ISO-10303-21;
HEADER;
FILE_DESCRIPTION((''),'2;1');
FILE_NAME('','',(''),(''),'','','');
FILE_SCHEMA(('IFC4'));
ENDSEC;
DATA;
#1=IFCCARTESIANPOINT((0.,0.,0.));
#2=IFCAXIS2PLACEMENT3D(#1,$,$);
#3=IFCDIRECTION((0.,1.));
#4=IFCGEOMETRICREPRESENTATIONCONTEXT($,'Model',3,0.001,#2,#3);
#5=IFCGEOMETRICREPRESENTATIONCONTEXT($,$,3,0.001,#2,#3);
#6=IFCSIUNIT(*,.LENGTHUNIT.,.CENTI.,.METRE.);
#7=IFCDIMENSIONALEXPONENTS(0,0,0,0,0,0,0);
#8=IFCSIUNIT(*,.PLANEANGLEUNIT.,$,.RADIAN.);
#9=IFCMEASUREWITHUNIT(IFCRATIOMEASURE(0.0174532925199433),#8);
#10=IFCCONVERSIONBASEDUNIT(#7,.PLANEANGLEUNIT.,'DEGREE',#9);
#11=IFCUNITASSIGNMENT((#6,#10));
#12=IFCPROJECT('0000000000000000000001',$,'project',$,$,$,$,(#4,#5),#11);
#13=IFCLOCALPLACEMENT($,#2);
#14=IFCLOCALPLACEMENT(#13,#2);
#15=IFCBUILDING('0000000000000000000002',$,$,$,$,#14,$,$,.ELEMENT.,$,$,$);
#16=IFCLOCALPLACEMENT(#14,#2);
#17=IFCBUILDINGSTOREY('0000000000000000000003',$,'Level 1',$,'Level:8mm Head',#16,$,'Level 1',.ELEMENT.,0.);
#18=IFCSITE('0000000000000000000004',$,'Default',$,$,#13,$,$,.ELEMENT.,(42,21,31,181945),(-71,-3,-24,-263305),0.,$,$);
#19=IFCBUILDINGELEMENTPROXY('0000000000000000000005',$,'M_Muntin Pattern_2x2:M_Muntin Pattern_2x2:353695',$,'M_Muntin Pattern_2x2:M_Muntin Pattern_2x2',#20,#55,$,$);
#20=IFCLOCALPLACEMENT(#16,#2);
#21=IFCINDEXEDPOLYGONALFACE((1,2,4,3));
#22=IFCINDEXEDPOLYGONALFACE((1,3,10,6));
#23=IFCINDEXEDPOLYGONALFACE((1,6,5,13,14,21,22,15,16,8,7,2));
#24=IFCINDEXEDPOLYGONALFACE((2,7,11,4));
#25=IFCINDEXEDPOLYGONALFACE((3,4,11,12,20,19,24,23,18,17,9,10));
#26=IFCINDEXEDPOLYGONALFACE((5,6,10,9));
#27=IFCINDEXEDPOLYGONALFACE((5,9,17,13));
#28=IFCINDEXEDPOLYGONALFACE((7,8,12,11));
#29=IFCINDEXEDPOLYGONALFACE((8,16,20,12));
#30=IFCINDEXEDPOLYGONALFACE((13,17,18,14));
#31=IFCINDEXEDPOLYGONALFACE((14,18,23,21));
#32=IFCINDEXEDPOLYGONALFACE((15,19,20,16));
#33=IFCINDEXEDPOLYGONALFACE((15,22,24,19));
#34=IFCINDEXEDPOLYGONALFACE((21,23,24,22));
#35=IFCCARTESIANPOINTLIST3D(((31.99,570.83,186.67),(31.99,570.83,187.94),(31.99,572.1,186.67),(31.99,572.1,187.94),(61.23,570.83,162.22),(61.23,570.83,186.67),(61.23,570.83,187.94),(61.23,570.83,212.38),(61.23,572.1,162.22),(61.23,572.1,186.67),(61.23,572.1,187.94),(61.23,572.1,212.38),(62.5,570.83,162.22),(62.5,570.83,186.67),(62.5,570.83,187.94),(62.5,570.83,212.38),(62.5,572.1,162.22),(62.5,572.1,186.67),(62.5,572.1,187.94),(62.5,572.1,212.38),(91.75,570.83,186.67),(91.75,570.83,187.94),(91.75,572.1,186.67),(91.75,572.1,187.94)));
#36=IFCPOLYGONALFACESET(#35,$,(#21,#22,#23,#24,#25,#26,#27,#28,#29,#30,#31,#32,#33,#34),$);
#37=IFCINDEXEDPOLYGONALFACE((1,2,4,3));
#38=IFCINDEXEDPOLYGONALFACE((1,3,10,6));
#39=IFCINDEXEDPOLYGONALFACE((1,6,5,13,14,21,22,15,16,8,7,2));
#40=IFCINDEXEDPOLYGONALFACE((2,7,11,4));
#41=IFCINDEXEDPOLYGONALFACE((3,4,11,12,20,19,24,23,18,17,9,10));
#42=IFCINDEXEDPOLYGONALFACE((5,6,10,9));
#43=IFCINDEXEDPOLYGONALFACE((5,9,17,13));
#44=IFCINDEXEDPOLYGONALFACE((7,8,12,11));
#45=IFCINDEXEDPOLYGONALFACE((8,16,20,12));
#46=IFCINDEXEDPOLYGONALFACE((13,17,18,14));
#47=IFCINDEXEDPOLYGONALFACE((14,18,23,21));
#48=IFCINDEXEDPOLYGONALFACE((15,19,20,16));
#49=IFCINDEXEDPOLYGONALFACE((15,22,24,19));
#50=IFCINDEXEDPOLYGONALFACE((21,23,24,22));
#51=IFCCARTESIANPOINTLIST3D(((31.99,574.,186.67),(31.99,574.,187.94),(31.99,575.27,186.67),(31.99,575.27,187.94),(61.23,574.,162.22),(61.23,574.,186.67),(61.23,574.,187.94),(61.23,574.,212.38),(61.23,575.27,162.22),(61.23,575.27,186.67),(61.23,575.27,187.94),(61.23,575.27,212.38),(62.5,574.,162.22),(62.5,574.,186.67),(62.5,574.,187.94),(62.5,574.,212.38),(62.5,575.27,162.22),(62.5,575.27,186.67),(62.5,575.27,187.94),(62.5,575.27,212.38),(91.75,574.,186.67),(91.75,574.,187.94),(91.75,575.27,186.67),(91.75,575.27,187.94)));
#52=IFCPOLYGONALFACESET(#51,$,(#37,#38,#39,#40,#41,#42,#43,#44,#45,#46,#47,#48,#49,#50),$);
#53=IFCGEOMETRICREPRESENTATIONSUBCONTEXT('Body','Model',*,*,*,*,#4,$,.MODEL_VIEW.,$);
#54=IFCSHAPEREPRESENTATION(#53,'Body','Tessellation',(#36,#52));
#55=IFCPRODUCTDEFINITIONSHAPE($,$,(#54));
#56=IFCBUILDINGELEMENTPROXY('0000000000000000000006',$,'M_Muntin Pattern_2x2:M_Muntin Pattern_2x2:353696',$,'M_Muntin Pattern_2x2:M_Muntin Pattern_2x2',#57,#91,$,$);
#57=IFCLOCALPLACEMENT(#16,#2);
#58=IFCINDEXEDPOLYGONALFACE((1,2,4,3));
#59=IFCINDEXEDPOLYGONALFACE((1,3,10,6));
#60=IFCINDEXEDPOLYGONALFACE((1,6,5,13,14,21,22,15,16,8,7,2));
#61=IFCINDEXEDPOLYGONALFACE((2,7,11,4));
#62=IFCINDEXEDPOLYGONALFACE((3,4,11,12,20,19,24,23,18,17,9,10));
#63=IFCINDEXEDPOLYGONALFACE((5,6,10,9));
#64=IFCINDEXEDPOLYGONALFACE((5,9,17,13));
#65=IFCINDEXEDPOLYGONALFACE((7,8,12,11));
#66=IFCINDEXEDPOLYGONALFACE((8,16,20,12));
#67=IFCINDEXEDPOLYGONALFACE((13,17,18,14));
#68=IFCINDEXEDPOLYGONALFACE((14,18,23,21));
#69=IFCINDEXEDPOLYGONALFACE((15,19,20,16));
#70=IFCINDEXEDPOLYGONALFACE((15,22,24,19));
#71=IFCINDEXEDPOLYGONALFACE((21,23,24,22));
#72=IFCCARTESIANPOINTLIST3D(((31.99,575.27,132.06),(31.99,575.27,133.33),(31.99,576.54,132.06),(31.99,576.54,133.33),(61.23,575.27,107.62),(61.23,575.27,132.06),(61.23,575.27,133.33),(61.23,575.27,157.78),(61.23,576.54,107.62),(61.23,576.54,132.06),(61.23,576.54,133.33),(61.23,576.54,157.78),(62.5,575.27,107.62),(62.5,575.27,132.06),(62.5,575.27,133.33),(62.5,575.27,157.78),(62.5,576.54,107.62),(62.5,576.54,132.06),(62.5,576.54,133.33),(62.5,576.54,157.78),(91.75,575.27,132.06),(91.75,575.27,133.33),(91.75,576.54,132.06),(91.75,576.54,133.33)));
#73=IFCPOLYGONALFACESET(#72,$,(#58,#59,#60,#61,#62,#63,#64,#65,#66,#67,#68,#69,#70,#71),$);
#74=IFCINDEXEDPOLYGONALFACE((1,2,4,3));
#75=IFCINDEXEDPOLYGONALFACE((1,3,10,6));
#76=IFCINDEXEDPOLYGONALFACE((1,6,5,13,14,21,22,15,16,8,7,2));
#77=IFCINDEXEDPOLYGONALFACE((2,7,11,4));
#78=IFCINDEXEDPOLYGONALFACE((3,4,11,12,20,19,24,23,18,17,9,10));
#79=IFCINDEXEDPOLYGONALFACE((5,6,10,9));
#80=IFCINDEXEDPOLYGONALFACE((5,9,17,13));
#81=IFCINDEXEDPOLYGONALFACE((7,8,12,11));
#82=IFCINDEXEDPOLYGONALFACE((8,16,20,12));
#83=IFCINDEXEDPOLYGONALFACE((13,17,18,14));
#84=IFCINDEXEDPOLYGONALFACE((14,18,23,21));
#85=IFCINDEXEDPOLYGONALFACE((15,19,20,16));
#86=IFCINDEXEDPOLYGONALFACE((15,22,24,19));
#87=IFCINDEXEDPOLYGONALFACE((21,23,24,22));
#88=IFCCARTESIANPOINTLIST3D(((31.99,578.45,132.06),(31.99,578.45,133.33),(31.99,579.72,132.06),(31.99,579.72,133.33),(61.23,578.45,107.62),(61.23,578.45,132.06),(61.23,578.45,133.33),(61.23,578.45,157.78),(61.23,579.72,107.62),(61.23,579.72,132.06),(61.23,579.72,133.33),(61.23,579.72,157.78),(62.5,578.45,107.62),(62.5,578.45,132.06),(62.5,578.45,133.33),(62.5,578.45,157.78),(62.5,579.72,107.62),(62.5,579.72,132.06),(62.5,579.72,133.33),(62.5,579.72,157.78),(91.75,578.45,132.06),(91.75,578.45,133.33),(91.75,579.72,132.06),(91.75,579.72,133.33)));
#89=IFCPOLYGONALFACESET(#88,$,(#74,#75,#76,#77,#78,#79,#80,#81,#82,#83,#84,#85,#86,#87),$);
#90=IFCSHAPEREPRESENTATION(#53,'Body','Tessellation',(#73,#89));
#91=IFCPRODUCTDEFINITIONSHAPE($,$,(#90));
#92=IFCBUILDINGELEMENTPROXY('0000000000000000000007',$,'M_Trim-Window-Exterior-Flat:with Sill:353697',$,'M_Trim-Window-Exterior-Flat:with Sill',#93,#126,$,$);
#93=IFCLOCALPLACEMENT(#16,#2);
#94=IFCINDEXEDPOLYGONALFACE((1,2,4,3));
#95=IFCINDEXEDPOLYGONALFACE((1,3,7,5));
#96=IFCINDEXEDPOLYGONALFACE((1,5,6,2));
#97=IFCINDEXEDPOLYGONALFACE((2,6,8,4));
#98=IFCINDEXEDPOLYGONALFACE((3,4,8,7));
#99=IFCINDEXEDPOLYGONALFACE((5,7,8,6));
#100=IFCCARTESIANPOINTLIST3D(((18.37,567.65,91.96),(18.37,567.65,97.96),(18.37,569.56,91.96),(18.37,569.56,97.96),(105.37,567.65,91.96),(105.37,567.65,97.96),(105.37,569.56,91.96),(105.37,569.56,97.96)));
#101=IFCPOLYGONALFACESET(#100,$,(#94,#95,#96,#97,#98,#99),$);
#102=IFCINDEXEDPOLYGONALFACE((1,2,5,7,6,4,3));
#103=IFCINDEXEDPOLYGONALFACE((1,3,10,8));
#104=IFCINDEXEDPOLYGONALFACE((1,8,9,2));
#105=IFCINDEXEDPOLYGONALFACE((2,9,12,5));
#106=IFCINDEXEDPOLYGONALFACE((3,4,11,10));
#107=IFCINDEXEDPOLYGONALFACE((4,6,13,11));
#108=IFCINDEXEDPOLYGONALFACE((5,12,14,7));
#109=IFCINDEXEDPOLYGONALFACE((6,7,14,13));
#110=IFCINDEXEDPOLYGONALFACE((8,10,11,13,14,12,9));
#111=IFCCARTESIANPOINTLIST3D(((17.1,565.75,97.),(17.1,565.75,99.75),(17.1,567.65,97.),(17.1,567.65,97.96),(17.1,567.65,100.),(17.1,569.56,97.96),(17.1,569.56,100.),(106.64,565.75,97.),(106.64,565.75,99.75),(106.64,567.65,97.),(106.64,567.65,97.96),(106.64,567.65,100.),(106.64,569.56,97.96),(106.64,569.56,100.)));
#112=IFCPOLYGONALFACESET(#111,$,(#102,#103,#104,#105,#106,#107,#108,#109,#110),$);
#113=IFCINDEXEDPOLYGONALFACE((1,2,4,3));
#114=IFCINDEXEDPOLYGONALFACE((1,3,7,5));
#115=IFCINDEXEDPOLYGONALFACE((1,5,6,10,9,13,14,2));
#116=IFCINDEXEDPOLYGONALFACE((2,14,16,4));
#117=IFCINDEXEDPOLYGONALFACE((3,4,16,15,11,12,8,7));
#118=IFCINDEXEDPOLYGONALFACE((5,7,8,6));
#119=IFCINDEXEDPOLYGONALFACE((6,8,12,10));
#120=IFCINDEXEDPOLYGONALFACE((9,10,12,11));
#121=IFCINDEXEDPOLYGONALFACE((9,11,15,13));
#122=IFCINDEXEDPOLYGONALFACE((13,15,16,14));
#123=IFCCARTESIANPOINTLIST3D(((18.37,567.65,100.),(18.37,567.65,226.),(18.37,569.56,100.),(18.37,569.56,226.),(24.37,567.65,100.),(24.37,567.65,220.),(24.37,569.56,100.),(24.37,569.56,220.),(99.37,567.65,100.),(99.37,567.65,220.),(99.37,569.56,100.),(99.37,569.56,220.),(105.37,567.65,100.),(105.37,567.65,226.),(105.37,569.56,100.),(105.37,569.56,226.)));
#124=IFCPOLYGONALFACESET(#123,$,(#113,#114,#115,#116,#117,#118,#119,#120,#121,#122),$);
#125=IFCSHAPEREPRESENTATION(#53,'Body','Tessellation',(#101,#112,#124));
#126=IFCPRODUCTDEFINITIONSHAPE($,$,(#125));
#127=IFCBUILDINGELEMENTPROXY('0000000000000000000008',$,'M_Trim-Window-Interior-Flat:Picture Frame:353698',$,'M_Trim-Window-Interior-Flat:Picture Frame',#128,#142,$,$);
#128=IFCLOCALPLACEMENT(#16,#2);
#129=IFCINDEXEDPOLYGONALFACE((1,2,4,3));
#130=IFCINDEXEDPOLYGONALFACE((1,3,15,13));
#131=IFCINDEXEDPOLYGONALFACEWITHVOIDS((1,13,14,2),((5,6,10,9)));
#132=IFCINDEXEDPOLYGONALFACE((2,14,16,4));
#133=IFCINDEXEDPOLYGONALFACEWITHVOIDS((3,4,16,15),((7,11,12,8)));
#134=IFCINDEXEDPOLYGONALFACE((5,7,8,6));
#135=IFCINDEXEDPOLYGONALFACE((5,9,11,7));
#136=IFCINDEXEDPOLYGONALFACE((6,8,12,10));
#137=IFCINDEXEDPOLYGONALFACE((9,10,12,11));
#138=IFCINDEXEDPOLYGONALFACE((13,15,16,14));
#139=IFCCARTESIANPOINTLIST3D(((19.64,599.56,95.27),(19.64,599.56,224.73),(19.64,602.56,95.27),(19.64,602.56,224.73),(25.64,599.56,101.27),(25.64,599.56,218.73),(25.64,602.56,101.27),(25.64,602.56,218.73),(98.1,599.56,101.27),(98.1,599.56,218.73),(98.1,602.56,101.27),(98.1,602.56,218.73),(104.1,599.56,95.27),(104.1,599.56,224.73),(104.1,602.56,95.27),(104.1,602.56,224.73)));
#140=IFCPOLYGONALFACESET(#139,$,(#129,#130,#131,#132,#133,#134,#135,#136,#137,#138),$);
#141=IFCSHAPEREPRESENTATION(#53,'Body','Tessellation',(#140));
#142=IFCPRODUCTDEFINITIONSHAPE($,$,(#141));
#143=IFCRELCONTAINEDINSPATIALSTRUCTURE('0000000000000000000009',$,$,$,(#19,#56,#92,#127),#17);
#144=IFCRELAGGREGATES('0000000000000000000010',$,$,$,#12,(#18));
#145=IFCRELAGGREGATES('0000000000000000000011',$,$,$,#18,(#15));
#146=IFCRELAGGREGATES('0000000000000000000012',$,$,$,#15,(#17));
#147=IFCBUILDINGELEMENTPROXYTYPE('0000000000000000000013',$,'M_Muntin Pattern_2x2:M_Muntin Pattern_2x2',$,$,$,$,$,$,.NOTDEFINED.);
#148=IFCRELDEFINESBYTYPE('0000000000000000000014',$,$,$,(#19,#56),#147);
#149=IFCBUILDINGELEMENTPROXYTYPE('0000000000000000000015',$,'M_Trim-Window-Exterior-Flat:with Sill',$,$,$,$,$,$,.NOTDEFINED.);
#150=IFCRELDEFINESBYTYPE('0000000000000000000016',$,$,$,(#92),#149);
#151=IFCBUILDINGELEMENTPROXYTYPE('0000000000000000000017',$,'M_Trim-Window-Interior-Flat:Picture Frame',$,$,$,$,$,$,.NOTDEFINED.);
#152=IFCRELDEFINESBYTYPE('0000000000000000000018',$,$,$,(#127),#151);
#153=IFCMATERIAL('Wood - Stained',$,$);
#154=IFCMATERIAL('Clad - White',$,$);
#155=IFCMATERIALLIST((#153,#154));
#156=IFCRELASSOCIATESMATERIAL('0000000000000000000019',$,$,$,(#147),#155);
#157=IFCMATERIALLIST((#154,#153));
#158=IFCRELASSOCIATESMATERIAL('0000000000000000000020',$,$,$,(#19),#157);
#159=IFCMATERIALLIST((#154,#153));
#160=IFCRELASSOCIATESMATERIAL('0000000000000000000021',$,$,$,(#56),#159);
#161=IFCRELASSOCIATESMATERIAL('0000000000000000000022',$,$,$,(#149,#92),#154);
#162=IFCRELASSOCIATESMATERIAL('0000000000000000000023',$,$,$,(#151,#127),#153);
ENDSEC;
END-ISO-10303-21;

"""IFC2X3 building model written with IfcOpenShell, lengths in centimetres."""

from ifc_helpers import new_model, entity, si_unit, converted_unit, direction, frame, frame_2d, origin, place, context, subcontext, project, spatial, polyline, rectangle, outline, extrude, source, transform, mapped, material, material_list, type_object, type_shapes, element, save


model = new_model("IFC2X3")

# Units and contexts
model_context = context("Model", 3, precision=0.001, world=origin(), true_north=direction((0.0, 1.0)))
context_of_model = context(None, 3, precision=0.001, world=origin(), true_north=direction((0.0, 1.0)))
body_context = subcontext(model_context, "Body", "Model", "MODEL_VIEW")
ifc_project = project(units=[si_unit("LENGTHUNIT", "METRE", prefix="CENTI"), converted_unit("PLANEANGLEUNIT", "DEGREE", entity("IfcRatioMeasure", 0.0174532925199433), si_unit("PLANEANGLEUNIT", "RADIAN"), dimensions=[0, 0, 0, 0, 0, 0, 0])], contexts=[model_context, context_of_model])

# Site, building, storey
site_placement = place(None, origin())
site = spatial("IfcSite", under=ifc_project, at=site_placement, Name="Default", CompositionType="ELEMENT", RefLatitude=(42, 21, 31, 181945), RefLongitude=(-71, -3, -24, -263305), RefElevation=0.0)
building_placement = place(site_placement, origin())
building = spatial("IfcBuilding", under=site, at=building_placement, CompositionType="ELEMENT")
storey_placement = place(building_placement, origin())
storey = spatial("IfcBuildingStorey", under=building, at=storey_placement, Name="Level 1", ObjectType="Level:8mm Head", LongName="Level 1", CompositionType="ELEMENT", Elevation=0.0)

# Shared definitions
ifc_material_1 = material(Name="Wood - Stained")
ifc_material_2 = material(Name="Clad - White")

# Building element proxies
ifc_material_list_1 = material_list([ifc_material_2, ifc_material_1])
ifc_material_list_2 = material_list([ifc_material_1, ifc_material_2])
building_element_proxy_type_1 = type_object("IfcBuildingElementProxyType", Name="M_Muntin Pattern_2x2:M_Muntin Pattern_2x2", PredefinedType="NOTDEFINED", material=ifc_material_list_2)
shared_shape_1 = source(origin(), body_context, "Body", "SweptSolid", [
    extrude(outline(polyline([(0.64, -0.64), (25.08, -0.64), (25.08, 0.63), (0.64, 0.63), (0.64, 29.88), (-0.63, 29.88), (-0.63, 0.63), (-25.08, 0.63), (-25.08, -0.64), (-0.63, -0.64), (-0.63, -29.88), (0.64, -29.88), (0.64, -0.64)])), frame((0.0, 0.95, 25.08), z_axis=(0.0, 1.0, 0.0), x_axis=(0.0, 0.0, 1.0)), (0.0, 0.0, 1.0), 1.27),
    extrude(outline(polyline([(0.64, -0.64), (25.08, -0.64), (25.08, 0.63), (0.64, 0.63), (0.64, 29.88), (-0.63, 29.88), (-0.63, 0.63), (-25.08, 0.63), (-25.08, -0.64), (-0.63, -0.64), (-0.63, -29.88), (0.64, -29.88), (0.64, -0.64)])), frame((0.0, -2.22, 25.08), z_axis=(0.0, 1.0, 0.0), x_axis=(0.0, 0.0, 1.0)), (0.0, 0.0, 1.0), 1.27),
])
type_shapes(building_element_proxy_type_1, [shared_shape_1])
proxy_1_placement = place(storey_placement, frame((61.87, 573.05, 162.22), z_axis=(0.0, 0.0, 1.0), x_axis=(-1.0, 0.0, 0.0)))
element("IfcBuildingElementProxy", 1, at=proxy_1_placement, inside=storey, type_object=building_element_proxy_type_1, material=ifc_material_list_1, Name="M_Muntin Pattern_2x2:M_Muntin Pattern_2x2:353695", ObjectType="M_Muntin Pattern_2x2:M_Muntin Pattern_2x2", context=body_context, shape_type="MappedRepresentation", body=[
    mapped(shared_shape_1, transform((0.0, 0.0, 0.0), scale=1.0)),
])
ifc_material_list_3 = material_list([ifc_material_2, ifc_material_1])
proxy_2_placement = place(storey_placement, frame((61.87, 577.49, 107.62), z_axis=(0.0, 0.0, 1.0), x_axis=(-1.0, 0.0, 0.0)))
element("IfcBuildingElementProxy", 2, at=proxy_2_placement, inside=storey, type_object=building_element_proxy_type_1, material=ifc_material_list_3, Name="M_Muntin Pattern_2x2:M_Muntin Pattern_2x2:353696", ObjectType="M_Muntin Pattern_2x2:M_Muntin Pattern_2x2", context=body_context, shape_type="MappedRepresentation", body=[
    mapped(shared_shape_1, transform((0.0, 0.0, 0.0), scale=1.0)),
])
building_element_proxy_type_2 = type_object("IfcBuildingElementProxyType", Name="M_Trim-Window-Exterior-Flat:with Sill", PredefinedType="NOTDEFINED", material=ifc_material_2)
shared_shape_2 = source(origin(), body_context, "Body", "SweptSolid", [
    extrude(rectangle(XDim=87.0, YDim=6.0, at=frame_2d((0.0, 0.0), x_axis=(1.0, 0.0))), frame((0.0, -125.04, 0.0), z_axis=(0.0, 0.0, 1.0), x_axis=(-1.0, 0.0, 0.0)), (0.0, 0.0, 1.0), 1.91),
    extrude(outline(polyline([(-1.9, -1.52), (0.0, -1.52), (0.0, -0.57), (1.9, -0.57), (1.9, 1.48), (0.0, 1.48), (-1.9, 1.23), (-1.9, -1.52)])), frame((-44.77, -121.48, 1.9), z_axis=(1.0, 0.0, 0.0), x_axis=(0.0, 0.0, -1.0)), (0.0, 0.0, 1.0), 89.54),
    extrude(outline(polyline([(-64.5, -43.5), (61.5, -43.5), (61.5, -37.5), (-58.5, -37.5), (-58.5, 37.5), (61.5, 37.5), (61.5, 43.5), (-64.5, 43.5), (-64.5, -43.5)])), frame((0.0, -58.5, 0.0), z_axis=(0.0, 0.0, 1.0), x_axis=(0.0, -1.0, 0.0)), (0.0, 0.0, 1.0), 1.91),
])
type_shapes(building_element_proxy_type_2, [shared_shape_2])
proxy_3_placement = place(storey_placement, frame((61.87, 569.56, 220.0), z_axis=(0.0, -1.0, 0.0), x_axis=(1.0, 0.0, 0.0)))
element("IfcBuildingElementProxy", 3, at=proxy_3_placement, inside=storey, type_object=building_element_proxy_type_2, material=ifc_material_2, Name="M_Trim-Window-Exterior-Flat:with Sill:353697", ObjectType="M_Trim-Window-Exterior-Flat:with Sill", context=body_context, shape_type="MappedRepresentation", body=[
    mapped(shared_shape_2, transform((0.0, 0.0, 0.0), scale=1.0)),
])
building_element_proxy_type_3 = type_object("IfcBuildingElementProxyType", Name="M_Trim-Window-Interior-Flat:Picture Frame", PredefinedType="NOTDEFINED", material=ifc_material_1)
shared_shape_3 = source(origin(), body_context, "Body", "SweptSolid", [
    extrude(outline(polyline([(-42.23, -64.73), (42.23, -64.73), (42.23, 64.73), (-42.23, 64.73), (-42.23, -64.73)]), holes=[polyline([(-36.23, -58.73), (-36.23, 58.73), (36.23, 58.73), (36.23, -58.73), (-36.23, -58.73)])]), frame((0.0, -60.0, 0.0), z_axis=(0.0, 0.0, 1.0), x_axis=(-1.0, 0.0, 0.0)), (0.0, 0.0, 1.0), 3.0),
])
type_shapes(building_element_proxy_type_3, [shared_shape_3])
proxy_4_placement = place(storey_placement, frame((61.87, 599.56, 220.0), z_axis=(0.0, 1.0, 0.0), x_axis=(-1.0, 0.0, 0.0)))
element("IfcBuildingElementProxy", 4, at=proxy_4_placement, inside=storey, type_object=building_element_proxy_type_3, material=ifc_material_1, Name="M_Trim-Window-Interior-Flat:Picture Frame:353698", ObjectType="M_Trim-Window-Interior-Flat:Picture Frame", context=body_context, shape_type="MappedRepresentation", body=[
    mapped(shared_shape_3, transform((0.0, 0.0, 0.0), scale=1.0)),
])

save(model, "model.ifc")
